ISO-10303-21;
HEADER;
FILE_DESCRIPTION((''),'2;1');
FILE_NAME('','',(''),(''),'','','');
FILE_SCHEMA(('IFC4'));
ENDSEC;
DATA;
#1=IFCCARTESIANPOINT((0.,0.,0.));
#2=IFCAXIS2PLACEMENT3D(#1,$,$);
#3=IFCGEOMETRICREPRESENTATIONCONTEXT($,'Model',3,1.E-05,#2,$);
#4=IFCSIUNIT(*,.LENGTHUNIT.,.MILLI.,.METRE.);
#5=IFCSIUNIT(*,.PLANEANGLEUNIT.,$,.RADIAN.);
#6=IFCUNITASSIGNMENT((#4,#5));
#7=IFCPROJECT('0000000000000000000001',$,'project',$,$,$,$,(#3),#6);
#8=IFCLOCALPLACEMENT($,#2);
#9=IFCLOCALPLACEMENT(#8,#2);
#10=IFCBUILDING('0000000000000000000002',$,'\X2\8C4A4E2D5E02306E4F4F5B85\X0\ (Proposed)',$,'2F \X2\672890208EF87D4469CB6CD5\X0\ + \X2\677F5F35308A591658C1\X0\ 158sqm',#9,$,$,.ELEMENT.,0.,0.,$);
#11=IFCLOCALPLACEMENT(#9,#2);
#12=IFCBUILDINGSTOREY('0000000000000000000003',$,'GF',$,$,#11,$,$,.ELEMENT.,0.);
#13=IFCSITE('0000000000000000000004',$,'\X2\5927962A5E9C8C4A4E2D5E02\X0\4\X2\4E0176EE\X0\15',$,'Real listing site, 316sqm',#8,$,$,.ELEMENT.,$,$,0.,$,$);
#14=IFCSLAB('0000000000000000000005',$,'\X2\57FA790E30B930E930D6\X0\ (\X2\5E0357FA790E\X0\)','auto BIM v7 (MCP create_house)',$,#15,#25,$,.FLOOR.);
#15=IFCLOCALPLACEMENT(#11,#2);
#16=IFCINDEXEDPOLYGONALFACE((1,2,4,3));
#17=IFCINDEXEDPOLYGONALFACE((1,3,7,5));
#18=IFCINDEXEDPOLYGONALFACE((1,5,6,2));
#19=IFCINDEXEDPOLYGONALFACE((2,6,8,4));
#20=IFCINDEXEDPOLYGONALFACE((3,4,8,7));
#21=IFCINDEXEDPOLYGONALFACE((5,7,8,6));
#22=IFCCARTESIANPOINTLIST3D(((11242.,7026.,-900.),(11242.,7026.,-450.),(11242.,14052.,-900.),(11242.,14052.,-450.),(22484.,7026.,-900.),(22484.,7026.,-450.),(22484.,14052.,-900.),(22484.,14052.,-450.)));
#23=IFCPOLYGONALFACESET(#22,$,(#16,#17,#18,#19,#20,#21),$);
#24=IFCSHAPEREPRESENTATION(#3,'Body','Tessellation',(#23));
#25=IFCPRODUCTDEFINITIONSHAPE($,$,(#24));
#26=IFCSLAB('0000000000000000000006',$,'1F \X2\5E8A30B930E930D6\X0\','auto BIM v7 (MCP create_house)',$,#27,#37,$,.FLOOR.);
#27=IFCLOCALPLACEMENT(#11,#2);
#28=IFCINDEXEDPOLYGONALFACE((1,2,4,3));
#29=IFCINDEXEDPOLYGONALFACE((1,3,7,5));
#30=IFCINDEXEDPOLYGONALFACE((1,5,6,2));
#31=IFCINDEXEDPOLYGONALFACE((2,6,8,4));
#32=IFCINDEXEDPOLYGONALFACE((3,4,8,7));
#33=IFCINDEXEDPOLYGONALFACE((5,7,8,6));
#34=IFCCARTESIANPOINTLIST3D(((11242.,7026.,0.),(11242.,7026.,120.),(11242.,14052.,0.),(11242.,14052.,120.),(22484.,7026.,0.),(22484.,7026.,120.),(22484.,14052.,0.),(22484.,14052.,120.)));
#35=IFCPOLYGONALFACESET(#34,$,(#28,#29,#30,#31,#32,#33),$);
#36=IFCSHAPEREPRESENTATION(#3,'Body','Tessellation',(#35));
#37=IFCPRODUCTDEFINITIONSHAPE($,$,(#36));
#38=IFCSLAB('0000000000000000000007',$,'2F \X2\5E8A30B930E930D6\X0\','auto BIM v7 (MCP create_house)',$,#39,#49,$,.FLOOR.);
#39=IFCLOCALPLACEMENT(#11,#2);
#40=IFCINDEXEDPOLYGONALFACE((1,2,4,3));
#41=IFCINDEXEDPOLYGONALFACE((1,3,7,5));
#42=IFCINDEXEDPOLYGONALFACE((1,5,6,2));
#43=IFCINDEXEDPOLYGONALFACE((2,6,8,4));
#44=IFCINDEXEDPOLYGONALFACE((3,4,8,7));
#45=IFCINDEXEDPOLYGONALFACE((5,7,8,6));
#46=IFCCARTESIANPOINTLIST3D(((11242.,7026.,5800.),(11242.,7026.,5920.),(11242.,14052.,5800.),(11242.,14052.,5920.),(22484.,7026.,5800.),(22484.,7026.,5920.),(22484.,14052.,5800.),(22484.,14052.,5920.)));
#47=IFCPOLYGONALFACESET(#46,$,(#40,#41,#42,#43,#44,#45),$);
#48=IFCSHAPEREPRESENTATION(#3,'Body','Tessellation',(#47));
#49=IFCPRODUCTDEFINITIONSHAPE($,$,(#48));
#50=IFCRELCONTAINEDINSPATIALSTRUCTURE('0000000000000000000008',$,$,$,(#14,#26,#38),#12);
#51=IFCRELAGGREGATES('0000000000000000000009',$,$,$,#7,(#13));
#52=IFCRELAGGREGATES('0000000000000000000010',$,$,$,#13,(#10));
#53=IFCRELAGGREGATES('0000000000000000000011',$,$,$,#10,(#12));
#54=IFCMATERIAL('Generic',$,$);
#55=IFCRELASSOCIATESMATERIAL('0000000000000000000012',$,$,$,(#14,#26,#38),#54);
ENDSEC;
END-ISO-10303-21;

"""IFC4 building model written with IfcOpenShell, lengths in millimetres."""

from ifc_helpers import new_model, si_unit, frame, frame_2d, origin, place, context, project, spatial, rectangle, extrude, material, element, save


model = new_model("IFC4")

# Units and contexts
model_context = context("Model", 3, precision=1e-05, world=origin())
ifc_project = project(units=[si_unit("LENGTHUNIT", "METRE", prefix="MILLI"), si_unit("PLANEANGLEUNIT", "RADIAN")], contexts=[model_context])

# Site, building, storey
site_placement = place(None, origin())
site = spatial("IfcSite", under=ifc_project, at=site_placement, Name="大阪府豊中市4丁目15", ObjectType="Real listing site, 316sqm", CompositionType="ELEMENT", RefElevation=0.0)
building_placement = place(site_placement, origin())
building = spatial("IfcBuilding", under=site, at=building_placement, Name="豊中市の住宅 (Proposed)", ObjectType="2F 木造軸組構法 + 板張り外壁 158sqm", CompositionType="ELEMENT", ElevationOfRefHeight=0.0, ElevationOfTerrain=0.0)
storey_placement = place(building_placement, origin())
storey = spatial("IfcBuildingStorey", under=building, at=storey_placement, Name="GF", CompositionType="ELEMENT", Elevation=0.0)

# Slabs
ifc_material = material(Name="Generic")
slab_1_placement = place(storey_placement, frame((5621.0, 3513.0, -450.0)))
element("IfcSlab", 1, at=slab_1_placement, inside=storey, material=ifc_material, Name="基礎スラブ (布基礎)", Description="auto BIM v7 (MCP create_house)", PredefinedType="FLOOR", context=model_context, shape_type="SweptSolid", body=[
    extrude(rectangle(XDim=11242.0, YDim=7026.0, at=frame_2d((5621.0, 3513.0))), frame((5621.0, 3513.0, -450.0)), (0.0, 0.0, 1.0), 450.0),
])
slab_2_placement = place(storey_placement, frame((5621.0, 3513.0, 0.0)))
element("IfcSlab", 2, at=slab_2_placement, inside=storey, material=ifc_material, Name="1F 床スラブ", Description="auto BIM v7 (MCP create_house)", PredefinedType="FLOOR", context=model_context, shape_type="SweptSolid", body=[
    extrude(rectangle(XDim=11242.0, YDim=7026.0, at=frame_2d((5621.0, 3513.0))), frame((5621.0, 3513.0, 0.0)), (0.0, 0.0, 1.0), 120.0),
])
slab_3_placement = place(storey_placement, frame((5621.0, 3513.0, 2900.0)))
element("IfcSlab", 3, at=slab_3_placement, inside=storey, material=ifc_material, Name="2F 床スラブ", Description="auto BIM v7 (MCP create_house)", PredefinedType="FLOOR", context=model_context, shape_type="SweptSolid", body=[
    extrude(rectangle(XDim=11242.0, YDim=7026.0, at=frame_2d((5621.0, 3513.0))), frame((5621.0, 3513.0, 2900.0)), (0.0, 0.0, 1.0), 120.0),
])

save(model, "model.ifc")
